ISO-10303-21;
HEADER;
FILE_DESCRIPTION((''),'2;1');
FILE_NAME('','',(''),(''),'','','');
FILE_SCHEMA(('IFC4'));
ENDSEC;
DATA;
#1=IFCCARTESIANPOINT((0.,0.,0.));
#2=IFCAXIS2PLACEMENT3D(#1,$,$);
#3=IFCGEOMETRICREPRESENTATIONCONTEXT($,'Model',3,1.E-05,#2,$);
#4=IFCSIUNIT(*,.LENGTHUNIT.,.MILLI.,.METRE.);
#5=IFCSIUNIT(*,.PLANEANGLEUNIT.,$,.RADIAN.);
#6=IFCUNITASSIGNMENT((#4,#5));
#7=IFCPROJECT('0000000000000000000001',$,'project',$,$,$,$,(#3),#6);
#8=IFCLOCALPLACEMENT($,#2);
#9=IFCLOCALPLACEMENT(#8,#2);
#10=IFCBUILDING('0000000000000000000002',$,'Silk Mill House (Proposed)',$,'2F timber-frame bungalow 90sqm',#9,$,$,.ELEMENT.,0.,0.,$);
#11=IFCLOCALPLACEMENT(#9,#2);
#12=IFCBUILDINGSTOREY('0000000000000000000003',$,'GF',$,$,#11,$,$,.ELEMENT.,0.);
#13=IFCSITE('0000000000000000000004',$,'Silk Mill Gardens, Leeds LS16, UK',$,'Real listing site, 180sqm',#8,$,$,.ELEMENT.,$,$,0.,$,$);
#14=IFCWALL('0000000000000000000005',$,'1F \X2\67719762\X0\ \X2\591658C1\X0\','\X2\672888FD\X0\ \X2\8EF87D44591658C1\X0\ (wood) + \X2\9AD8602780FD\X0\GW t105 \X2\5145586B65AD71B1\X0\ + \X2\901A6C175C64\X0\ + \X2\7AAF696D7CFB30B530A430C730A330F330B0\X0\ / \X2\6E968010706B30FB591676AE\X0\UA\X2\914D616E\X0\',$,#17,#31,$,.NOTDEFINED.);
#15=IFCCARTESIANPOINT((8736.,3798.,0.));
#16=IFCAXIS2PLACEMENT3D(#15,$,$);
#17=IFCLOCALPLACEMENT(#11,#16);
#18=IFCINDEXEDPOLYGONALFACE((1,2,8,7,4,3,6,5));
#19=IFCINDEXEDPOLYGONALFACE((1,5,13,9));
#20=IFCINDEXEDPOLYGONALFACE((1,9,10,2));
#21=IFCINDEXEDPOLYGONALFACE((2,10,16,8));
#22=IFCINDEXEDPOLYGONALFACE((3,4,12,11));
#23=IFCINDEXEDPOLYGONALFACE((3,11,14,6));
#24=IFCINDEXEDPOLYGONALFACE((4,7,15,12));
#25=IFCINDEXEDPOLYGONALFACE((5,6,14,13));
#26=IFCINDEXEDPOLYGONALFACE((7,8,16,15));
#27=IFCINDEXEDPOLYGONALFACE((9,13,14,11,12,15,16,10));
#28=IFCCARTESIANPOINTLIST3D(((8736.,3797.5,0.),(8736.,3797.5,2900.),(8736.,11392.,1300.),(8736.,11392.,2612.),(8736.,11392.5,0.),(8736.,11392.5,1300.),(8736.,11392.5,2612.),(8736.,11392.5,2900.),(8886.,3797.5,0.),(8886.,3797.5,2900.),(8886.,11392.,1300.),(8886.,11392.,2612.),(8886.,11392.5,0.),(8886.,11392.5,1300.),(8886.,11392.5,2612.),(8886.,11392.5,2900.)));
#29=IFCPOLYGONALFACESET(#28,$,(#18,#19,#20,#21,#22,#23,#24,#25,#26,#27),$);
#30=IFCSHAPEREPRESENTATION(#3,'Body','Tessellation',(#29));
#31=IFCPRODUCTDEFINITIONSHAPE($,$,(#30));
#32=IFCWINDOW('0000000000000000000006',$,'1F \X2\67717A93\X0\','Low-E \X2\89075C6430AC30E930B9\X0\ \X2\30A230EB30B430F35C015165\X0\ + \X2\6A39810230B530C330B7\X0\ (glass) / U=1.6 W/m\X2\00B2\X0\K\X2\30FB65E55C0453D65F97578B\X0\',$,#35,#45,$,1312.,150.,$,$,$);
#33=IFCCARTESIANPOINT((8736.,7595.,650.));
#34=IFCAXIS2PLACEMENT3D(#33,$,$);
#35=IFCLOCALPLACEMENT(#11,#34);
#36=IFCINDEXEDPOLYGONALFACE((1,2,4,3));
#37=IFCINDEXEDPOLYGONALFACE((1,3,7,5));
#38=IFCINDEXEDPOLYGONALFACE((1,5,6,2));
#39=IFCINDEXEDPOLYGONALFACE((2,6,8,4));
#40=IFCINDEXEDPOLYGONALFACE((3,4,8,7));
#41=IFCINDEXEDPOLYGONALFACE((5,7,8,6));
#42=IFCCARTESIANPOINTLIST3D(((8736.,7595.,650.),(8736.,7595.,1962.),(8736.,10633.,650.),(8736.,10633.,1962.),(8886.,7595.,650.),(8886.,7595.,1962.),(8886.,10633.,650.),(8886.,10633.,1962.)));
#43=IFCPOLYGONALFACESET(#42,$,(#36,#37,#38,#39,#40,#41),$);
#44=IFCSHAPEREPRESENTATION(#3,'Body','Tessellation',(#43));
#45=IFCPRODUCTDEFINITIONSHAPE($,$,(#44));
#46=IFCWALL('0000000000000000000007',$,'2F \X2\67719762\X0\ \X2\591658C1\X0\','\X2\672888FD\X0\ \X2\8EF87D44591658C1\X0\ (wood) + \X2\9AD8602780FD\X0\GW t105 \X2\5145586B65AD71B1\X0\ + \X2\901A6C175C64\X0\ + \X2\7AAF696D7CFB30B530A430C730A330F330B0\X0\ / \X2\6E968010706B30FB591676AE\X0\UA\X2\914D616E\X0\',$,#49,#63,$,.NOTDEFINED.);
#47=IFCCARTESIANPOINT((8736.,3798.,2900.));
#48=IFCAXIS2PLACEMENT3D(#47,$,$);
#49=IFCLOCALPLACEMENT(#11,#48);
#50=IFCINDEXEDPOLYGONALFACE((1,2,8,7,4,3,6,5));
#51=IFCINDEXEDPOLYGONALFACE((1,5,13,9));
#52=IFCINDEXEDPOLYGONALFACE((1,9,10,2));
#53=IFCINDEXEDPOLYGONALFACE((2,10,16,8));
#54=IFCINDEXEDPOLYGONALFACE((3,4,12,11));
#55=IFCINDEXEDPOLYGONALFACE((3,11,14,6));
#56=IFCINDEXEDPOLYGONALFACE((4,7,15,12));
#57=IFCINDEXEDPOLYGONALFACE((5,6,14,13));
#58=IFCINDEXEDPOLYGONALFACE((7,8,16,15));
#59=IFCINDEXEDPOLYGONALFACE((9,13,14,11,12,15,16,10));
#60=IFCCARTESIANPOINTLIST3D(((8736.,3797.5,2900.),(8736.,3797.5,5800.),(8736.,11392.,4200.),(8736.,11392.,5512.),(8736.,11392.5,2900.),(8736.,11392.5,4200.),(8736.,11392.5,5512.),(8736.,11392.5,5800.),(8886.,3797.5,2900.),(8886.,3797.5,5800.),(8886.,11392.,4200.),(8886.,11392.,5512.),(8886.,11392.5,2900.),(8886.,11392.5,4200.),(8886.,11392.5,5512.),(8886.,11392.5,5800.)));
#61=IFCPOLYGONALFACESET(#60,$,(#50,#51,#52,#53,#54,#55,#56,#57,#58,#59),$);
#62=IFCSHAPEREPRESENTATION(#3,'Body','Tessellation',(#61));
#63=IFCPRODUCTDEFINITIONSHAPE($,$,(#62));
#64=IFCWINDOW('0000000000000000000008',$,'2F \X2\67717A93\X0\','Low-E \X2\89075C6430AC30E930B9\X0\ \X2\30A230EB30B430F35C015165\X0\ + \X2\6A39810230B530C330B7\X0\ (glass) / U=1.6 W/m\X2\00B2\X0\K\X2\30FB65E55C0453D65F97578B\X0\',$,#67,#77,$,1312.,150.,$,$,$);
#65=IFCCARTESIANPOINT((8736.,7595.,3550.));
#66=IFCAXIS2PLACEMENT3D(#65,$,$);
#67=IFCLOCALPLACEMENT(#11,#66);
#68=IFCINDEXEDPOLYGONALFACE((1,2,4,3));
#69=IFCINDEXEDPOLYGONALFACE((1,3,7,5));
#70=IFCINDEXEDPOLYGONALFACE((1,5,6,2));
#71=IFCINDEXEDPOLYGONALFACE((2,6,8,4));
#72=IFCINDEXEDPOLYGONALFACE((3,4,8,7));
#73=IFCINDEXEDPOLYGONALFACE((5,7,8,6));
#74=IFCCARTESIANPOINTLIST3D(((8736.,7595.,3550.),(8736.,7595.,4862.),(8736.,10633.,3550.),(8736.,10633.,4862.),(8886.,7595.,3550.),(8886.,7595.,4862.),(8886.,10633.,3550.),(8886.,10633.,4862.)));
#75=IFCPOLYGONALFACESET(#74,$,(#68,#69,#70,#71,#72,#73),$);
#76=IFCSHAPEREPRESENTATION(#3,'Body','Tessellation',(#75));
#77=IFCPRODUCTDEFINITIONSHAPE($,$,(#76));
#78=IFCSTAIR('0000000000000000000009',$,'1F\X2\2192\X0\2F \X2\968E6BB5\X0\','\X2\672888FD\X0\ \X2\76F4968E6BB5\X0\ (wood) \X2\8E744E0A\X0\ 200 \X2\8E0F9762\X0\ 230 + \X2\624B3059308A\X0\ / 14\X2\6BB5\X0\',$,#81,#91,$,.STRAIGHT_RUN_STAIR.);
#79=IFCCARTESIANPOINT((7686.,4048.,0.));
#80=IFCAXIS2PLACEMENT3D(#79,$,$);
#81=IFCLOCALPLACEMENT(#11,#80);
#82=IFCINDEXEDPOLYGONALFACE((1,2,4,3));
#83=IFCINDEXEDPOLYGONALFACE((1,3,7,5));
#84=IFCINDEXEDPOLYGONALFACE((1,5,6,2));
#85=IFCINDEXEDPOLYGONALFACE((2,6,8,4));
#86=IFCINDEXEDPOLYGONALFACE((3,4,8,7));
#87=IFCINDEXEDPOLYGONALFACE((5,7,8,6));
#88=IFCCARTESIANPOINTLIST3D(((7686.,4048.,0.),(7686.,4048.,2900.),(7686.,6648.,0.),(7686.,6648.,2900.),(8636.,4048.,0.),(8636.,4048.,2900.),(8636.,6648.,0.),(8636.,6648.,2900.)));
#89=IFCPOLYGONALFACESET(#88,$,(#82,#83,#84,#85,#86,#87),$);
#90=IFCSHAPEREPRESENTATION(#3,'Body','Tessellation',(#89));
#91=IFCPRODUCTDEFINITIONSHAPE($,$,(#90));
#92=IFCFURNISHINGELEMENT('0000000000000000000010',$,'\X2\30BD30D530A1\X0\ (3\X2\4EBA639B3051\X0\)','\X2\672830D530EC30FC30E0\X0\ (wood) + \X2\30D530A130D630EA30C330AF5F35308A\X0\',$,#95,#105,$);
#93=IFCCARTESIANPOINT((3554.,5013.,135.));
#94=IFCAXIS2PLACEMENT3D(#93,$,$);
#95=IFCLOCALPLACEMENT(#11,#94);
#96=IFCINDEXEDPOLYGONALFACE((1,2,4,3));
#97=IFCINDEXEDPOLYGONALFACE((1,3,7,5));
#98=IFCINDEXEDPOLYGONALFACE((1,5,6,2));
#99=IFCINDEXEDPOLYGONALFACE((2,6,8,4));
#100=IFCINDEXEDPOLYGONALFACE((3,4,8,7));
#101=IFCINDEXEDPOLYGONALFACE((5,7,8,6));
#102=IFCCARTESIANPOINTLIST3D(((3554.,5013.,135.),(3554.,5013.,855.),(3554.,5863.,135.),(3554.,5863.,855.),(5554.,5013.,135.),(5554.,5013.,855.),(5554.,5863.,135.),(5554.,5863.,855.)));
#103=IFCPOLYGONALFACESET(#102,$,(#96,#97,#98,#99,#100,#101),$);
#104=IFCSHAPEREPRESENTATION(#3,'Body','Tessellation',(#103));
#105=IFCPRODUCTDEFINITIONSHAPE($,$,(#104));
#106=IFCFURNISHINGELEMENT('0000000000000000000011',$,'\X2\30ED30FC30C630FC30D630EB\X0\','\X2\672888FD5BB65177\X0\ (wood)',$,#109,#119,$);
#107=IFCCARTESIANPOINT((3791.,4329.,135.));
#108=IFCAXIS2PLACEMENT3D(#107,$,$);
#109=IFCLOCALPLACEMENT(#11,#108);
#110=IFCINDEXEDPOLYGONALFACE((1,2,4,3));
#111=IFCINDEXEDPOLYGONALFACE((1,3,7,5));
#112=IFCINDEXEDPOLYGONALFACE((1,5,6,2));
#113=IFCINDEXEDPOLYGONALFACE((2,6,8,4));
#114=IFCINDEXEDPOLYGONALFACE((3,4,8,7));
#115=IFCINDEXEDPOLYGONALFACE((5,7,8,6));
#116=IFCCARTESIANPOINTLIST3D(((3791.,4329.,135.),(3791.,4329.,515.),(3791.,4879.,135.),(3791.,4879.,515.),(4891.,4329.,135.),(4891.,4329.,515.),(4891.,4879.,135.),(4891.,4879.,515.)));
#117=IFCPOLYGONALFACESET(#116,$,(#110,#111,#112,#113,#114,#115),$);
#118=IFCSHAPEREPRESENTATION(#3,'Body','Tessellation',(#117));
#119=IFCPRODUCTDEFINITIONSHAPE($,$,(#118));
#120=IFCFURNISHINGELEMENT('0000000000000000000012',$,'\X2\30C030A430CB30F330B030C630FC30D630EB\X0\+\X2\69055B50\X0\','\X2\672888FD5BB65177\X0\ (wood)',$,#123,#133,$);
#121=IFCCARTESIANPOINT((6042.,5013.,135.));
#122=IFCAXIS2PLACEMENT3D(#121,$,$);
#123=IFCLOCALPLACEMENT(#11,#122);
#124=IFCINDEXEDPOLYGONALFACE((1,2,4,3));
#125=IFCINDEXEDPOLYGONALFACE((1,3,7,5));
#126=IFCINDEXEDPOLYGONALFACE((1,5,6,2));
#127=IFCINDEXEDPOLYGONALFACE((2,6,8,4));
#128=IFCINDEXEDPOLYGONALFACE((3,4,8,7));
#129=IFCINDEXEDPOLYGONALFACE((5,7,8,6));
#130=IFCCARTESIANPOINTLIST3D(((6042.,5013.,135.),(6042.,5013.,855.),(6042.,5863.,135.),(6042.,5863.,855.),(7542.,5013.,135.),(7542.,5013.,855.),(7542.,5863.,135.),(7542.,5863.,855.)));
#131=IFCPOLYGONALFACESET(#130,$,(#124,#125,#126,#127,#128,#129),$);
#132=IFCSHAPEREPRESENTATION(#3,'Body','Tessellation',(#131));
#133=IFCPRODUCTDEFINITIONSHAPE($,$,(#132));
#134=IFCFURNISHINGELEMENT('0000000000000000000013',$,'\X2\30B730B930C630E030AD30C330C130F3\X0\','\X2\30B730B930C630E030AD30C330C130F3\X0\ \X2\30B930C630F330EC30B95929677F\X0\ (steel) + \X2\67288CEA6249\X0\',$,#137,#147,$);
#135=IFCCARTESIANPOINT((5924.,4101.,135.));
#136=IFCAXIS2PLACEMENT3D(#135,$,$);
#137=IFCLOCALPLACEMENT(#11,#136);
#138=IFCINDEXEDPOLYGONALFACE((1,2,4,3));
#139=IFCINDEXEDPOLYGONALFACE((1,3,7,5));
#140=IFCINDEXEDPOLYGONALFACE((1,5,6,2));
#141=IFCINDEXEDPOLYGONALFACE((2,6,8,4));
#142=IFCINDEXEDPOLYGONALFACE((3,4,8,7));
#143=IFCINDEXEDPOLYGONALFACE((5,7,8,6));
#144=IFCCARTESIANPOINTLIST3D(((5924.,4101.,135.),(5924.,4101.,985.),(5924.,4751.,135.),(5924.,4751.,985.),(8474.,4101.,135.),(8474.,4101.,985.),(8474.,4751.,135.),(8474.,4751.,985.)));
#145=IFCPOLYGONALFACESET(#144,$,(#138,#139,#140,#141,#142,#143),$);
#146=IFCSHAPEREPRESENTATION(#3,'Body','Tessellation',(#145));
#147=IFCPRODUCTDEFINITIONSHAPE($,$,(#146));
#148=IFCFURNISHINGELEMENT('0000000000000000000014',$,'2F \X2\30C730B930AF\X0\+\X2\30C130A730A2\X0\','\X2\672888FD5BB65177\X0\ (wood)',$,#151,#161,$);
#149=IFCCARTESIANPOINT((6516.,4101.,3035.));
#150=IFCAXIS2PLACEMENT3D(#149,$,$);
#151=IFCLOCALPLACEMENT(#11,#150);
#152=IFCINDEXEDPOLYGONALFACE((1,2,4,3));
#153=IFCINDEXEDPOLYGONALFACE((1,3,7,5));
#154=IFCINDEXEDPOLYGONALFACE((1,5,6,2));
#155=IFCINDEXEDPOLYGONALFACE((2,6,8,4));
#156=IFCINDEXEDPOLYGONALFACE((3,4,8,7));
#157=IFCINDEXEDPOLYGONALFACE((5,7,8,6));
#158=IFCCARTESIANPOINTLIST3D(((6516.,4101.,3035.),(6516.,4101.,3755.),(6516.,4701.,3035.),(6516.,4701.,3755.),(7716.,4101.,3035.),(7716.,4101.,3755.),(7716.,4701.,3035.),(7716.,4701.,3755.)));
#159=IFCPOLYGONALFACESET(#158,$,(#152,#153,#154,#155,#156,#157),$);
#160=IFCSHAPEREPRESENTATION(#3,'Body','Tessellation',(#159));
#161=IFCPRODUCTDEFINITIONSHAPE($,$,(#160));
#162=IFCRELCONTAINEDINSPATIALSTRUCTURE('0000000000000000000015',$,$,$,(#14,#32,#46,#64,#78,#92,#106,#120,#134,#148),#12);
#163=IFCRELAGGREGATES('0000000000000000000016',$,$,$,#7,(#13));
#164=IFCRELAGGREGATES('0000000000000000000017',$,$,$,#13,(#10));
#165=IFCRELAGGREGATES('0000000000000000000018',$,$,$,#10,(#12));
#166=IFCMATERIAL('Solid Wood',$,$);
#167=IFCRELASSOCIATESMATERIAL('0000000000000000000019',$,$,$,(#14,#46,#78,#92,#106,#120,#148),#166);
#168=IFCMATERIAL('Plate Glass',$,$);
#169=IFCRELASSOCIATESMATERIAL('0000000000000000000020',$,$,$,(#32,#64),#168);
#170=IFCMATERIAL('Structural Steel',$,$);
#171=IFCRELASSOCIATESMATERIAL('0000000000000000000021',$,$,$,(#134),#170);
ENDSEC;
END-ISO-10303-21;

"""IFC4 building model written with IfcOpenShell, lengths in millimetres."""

from ifc_helpers import new_model, si_unit, frame, frame_2d, origin, place, context, project, spatial, rectangle, extrude, material, element, fill, save


model = new_model("IFC4")

# Units and contexts
model_context = context("Model", 3, precision=1e-05, world=origin())
ifc_project = project(units=[si_unit("LENGTHUNIT", "METRE", prefix="MILLI"), si_unit("PLANEANGLEUNIT", "RADIAN")], contexts=[model_context])

# Site, building, storey
site_placement = place(None, origin())
site = spatial("IfcSite", under=ifc_project, at=site_placement, Name="Silk Mill Gardens, Leeds LS16, UK", ObjectType="Real listing site, 180sqm", CompositionType="ELEMENT", RefElevation=0.0)
building_placement = place(site_placement, origin())
building = spatial("IfcBuilding", under=site, at=building_placement, Name="Silk Mill House (Proposed)", ObjectType="2F timber-frame bungalow 90sqm", CompositionType="ELEMENT", ElevationOfRefHeight=0.0, ElevationOfTerrain=0.0)
storey_placement = place(building_placement, origin())
storey = spatial("IfcBuildingStorey", under=building, at=storey_placement, Name="GF", CompositionType="ELEMENT", Elevation=0.0)

# Wall, opening, window
ifc_material_1 = material(Name="Solid Wood")
wall_1_placement = place(storey_placement, frame((8736.0, 3798.0, 0.0)))
wall_1 = element("IfcWall", 1, at=wall_1_placement, inside=storey, material=ifc_material_1, Name="1F 東面 外壁", Description="木製 軸組外壁 (wood) + 高性能GW t105 充填断熱 + 通気層 + 窯業系サイディング / 準耐火・外皮UA配慮", PredefinedType="NOTDEFINED", context=model_context, shape_type="SweptSolid", body=[
    extrude(rectangle(XDim=150.0, YDim=7595.0, at=frame_2d((75.0, 3797.0))), frame((8736.0, 3798.0, 0.0)), (0.0, 0.0, 1.0), 2900.0),
])
opening_1_placement = place(storey_placement, frame((8736.0, 7595.0, 650.0)))
opening_1 = element("IfcOpeningElement", 2, at=opening_1_placement, cuts=wall_1, PredefinedType="NOTDEFINED", context=model_context, shape_type="SweptSolid", body=[
    extrude(rectangle(XDim=150.0, YDim=3038.0, at=frame_2d((75.0, 1519.0))), frame((8736.0, 7595.0, 650.0)), (0.0, 0.0, 1.0), 1312.0),
])
ifc_material_2 = material(Name="Plate Glass")
window_1_placement = place(storey_placement, frame((8736.0, 7595.0, 650.0)))
window_1 = element("IfcWindow", 3, at=window_1_placement, inside=storey, material=ifc_material_2, Name="1F 東窓", Description="Low-E 複層ガラス アルゴン封入 + 樹脂サッシ (glass) / U=1.6 W/m²K・日射取得型", OverallHeight=1312.0, OverallWidth=150.0, context=model_context, shape_type="SweptSolid", body=[
    extrude(rectangle(XDim=150.0, YDim=3038.0, at=frame_2d((75.0, 1519.0))), frame((8736.0, 7595.0, 650.0)), (0.0, 0.0, 1.0), 1312.0),
])
fill(opening_1, window_1)

# Wall, opening, window
wall_2_placement = place(storey_placement, frame((8736.0, 3798.0, 2900.0)))
wall_2 = element("IfcWall", 4, at=wall_2_placement, inside=storey, material=ifc_material_1, Name="2F 東面 外壁", Description="木製 軸組外壁 (wood) + 高性能GW t105 充填断熱 + 通気層 + 窯業系サイディング / 準耐火・外皮UA配慮", PredefinedType="NOTDEFINED", context=model_context, shape_type="SweptSolid", body=[
    extrude(rectangle(XDim=150.0, YDim=7595.0, at=frame_2d((75.0, 3797.0))), frame((8736.0, 3798.0, 2900.0)), (0.0, 0.0, 1.0), 2900.0),
])
opening_2_placement = place(storey_placement, frame((8736.0, 7595.0, 3550.0)))
opening_2 = element("IfcOpeningElement", 5, at=opening_2_placement, cuts=wall_2, PredefinedType="NOTDEFINED", context=model_context, shape_type="SweptSolid", body=[
    extrude(rectangle(XDim=150.0, YDim=3038.0, at=frame_2d((75.0, 1519.0))), frame((8736.0, 7595.0, 3550.0)), (0.0, 0.0, 1.0), 1312.0),
])
window_2_placement = place(storey_placement, frame((8736.0, 7595.0, 3550.0)))
window_2 = element("IfcWindow", 6, at=window_2_placement, inside=storey, material=ifc_material_2, Name="2F 東窓", Description="Low-E 複層ガラス アルゴン封入 + 樹脂サッシ (glass) / U=1.6 W/m²K・日射取得型", OverallHeight=1312.0, OverallWidth=150.0, context=model_context, shape_type="SweptSolid", body=[
    extrude(rectangle(XDim=150.0, YDim=3038.0, at=frame_2d((75.0, 1519.0))), frame((8736.0, 7595.0, 3550.0)), (0.0, 0.0, 1.0), 1312.0),
])
fill(opening_2, window_2)

# Stair
stair_placement = place(storey_placement, frame((7686.0, 4048.0, 0.0)))
element("IfcStair", 7, at=stair_placement, inside=storey, material=ifc_material_1, Name="1F→2F 階段", Description="木製 直階段 (wood) 蹴上 200 踏面 230 + 手すり / 14段", PredefinedType="STRAIGHT_RUN_STAIR", context=model_context, shape_type="SweptSolid", body=[
    extrude(rectangle(XDim=950.0, YDim=2600.0, at=frame_2d((475.0, 1300.0))), frame((7686.0, 4048.0, 0.0)), (0.0, 0.0, 1.0), 2900.0),
])

# Furnishing elements
furnishing_1_placement = place(storey_placement, frame((3554.0, 5013.0, 135.0)))
element("IfcFurnishingElement", 8, at=furnishing_1_placement, inside=storey, material=ifc_material_1, Name="ソファ (3人掛け)", Description="木フレーム (wood) + ファブリック張り", context=model_context, shape_type="SweptSolid", body=[
    extrude(rectangle(XDim=2000.0, YDim=850.0, at=frame_2d((1000.0, 425.0))), frame((3554.0, 5013.0, 135.0)), (0.0, 0.0, 1.0), 720.0),
])
furnishing_2_placement = place(storey_placement, frame((3791.0, 4329.0, 135.0)))
element("IfcFurnishingElement", 9, at=furnishing_2_placement, inside=storey, material=ifc_material_1, Name="ローテーブル", Description="木製家具 (wood)", context=model_context, shape_type="SweptSolid", body=[
    extrude(rectangle(XDim=1100.0, YDim=550.0, at=frame_2d((550.0, 275.0))), frame((3791.0, 4329.0, 135.0)), (0.0, 0.0, 1.0), 380.0),
])
furnishing_3_placement = place(storey_placement, frame((6042.0, 5013.0, 135.0)))
element("IfcFurnishingElement", 10, at=furnishing_3_placement, inside=storey, material=ifc_material_1, Name="ダイニングテーブル+椅子", Description="木製家具 (wood)", context=model_context, shape_type="SweptSolid", body=[
    extrude(rectangle(XDim=1500.0, YDim=850.0, at=frame_2d((750.0, 425.0))), frame((6042.0, 5013.0, 135.0)), (0.0, 0.0, 1.0), 720.0),
])
ifc_material_3 = material(Name="Structural Steel")
furnishing_4_placement = place(storey_placement, frame((5924.0, 4101.0, 135.0)))
element("IfcFurnishingElement", 11, at=furnishing_4_placement, inside=storey, material=ifc_material_3, Name="システムキッチン", Description="システムキッチン ステンレス天板 (steel) + 木質扉", context=model_context, shape_type="SweptSolid", body=[
    extrude(rectangle(XDim=2550.0, YDim=650.0, at=frame_2d((1275.0, 325.0))), frame((5924.0, 4101.0, 135.0)), (0.0, 0.0, 1.0), 850.0),
])
furnishing_5_placement = place(storey_placement, frame((6516.0, 4101.0, 3035.0)))
element("IfcFurnishingElement", 12, at=furnishing_5_placement, inside=storey, material=ifc_material_1, Name="2F デスク+チェア", Description="木製家具 (wood)", context=model_context, shape_type="SweptSolid", body=[
    extrude(rectangle(XDim=1200.0, YDim=600.0, at=frame_2d((600.0, 300.0))), frame((6516.0, 4101.0, 3035.0)), (0.0, 0.0, 1.0), 720.0),
])

save(model, "model.ifc")
